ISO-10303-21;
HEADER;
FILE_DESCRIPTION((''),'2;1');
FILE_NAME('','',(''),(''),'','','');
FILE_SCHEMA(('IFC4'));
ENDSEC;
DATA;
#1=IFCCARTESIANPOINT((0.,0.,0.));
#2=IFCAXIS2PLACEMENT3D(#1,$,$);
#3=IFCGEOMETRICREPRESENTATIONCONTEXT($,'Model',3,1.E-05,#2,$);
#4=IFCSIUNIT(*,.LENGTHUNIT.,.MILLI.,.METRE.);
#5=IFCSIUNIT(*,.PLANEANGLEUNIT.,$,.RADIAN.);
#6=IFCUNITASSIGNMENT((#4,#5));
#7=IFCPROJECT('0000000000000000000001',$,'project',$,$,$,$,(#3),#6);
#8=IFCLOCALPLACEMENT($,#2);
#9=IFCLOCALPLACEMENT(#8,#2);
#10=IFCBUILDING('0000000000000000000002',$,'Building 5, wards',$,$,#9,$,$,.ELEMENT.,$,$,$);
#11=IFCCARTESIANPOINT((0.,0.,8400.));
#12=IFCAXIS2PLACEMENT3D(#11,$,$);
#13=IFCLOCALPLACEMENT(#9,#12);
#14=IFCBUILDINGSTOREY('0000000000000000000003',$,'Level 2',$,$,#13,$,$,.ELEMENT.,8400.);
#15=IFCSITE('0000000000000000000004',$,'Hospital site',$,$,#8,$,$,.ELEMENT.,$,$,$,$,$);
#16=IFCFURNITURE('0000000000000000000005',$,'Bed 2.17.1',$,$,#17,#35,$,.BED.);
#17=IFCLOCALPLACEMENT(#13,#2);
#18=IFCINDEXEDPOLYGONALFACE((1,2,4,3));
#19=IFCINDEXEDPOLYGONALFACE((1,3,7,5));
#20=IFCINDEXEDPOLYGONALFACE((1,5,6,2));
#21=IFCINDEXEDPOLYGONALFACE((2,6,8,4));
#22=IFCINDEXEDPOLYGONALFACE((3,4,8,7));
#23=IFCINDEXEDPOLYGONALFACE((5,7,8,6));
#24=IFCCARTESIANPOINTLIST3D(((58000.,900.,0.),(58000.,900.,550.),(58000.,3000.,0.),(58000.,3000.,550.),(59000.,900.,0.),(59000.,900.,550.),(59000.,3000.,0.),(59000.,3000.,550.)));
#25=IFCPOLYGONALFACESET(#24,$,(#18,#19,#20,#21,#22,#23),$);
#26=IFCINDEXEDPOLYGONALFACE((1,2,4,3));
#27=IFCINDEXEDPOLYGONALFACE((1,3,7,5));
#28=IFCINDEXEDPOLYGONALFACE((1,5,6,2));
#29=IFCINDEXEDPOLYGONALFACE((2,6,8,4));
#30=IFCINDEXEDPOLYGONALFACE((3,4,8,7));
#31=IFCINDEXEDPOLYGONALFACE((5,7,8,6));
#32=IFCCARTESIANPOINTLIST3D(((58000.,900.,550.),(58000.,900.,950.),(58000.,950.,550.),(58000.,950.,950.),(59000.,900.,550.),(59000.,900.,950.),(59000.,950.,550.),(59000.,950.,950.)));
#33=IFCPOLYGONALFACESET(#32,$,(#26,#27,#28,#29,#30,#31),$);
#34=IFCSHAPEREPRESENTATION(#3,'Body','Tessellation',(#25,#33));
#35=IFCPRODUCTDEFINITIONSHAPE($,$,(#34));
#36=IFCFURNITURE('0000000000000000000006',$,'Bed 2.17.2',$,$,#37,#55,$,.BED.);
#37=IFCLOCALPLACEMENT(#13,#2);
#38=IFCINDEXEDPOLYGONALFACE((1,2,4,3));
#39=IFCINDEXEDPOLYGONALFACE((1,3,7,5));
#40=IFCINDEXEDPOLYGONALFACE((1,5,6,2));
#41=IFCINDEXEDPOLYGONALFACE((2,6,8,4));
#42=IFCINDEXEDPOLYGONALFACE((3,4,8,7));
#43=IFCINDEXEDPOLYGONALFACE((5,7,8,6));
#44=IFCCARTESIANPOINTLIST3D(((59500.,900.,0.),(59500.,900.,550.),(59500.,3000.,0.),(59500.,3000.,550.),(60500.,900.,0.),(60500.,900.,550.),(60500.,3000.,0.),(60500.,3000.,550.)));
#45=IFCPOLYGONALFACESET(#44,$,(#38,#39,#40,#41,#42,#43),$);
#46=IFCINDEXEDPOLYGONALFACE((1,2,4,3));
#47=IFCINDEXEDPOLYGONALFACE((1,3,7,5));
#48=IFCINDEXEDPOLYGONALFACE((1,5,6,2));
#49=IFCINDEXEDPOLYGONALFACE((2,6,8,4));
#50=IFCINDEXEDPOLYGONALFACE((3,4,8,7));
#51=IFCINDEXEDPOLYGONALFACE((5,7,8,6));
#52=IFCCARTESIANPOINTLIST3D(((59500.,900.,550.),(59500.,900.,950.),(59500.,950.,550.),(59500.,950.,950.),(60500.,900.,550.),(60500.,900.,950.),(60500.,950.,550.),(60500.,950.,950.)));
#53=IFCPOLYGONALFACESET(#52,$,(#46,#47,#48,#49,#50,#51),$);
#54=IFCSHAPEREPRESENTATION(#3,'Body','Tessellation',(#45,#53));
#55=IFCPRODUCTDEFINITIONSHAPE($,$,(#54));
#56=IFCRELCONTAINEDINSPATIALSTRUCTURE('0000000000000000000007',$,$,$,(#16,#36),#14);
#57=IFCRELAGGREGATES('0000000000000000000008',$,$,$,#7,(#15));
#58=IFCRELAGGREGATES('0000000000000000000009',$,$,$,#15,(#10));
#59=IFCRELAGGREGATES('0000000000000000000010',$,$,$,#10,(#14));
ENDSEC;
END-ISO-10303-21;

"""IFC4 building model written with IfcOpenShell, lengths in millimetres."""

from ifc_helpers import new_model, si_unit, frame, frame_2d, origin, place, context, project, spatial, rectangle, extrude, element, save


model = new_model("IFC4")

# Units and contexts
model_context = context("Model", 3, precision=1e-05, world=origin())
ifc_project = project(units=[si_unit("LENGTHUNIT", "METRE", prefix="MILLI"), si_unit("PLANEANGLEUNIT", "RADIAN")], contexts=[model_context])

# Site, building, storey
site_placement = place(None, origin())
site = spatial("IfcSite", under=ifc_project, at=site_placement, Name="Hospital site", CompositionType="ELEMENT")
building_placement = place(site_placement, origin())
building = spatial("IfcBuilding", under=site, at=building_placement, Name="Building 5, wards", CompositionType="ELEMENT")
storey_placement = place(building_placement, frame((0.0, 0.0, 8400.0)))
storey = spatial("IfcBuildingStorey", under=building, at=storey_placement, Name="Level 2", CompositionType="ELEMENT", Elevation=8400.0)

# Furniture
for number, where, name in (
    (1, (58000.0, 900.0, 0.0), "Bed 2.17.1"),
    (2, (59500.0, 900.0, 0.0), "Bed 2.17.2"),
):
    element("IfcFurniture", number, at=place(storey_placement, frame(where)), inside=storey, Name=name, PredefinedType="BED", context=model_context, shape_type="SweptSolid", body=[
        extrude(rectangle(XDim=1000.0, YDim=2100.0, at=frame_2d((500.0, 1050.0))), origin(), (0.0, 0.0, 1.0), 550.0),
        extrude(rectangle(XDim=1000.0, YDim=50.0, at=frame_2d((500.0, 25.0))), frame((0.0, 0.0, 550.0)), (0.0, 0.0, 1.0), 400.0),
    ])

save(model, "model.ifc")
